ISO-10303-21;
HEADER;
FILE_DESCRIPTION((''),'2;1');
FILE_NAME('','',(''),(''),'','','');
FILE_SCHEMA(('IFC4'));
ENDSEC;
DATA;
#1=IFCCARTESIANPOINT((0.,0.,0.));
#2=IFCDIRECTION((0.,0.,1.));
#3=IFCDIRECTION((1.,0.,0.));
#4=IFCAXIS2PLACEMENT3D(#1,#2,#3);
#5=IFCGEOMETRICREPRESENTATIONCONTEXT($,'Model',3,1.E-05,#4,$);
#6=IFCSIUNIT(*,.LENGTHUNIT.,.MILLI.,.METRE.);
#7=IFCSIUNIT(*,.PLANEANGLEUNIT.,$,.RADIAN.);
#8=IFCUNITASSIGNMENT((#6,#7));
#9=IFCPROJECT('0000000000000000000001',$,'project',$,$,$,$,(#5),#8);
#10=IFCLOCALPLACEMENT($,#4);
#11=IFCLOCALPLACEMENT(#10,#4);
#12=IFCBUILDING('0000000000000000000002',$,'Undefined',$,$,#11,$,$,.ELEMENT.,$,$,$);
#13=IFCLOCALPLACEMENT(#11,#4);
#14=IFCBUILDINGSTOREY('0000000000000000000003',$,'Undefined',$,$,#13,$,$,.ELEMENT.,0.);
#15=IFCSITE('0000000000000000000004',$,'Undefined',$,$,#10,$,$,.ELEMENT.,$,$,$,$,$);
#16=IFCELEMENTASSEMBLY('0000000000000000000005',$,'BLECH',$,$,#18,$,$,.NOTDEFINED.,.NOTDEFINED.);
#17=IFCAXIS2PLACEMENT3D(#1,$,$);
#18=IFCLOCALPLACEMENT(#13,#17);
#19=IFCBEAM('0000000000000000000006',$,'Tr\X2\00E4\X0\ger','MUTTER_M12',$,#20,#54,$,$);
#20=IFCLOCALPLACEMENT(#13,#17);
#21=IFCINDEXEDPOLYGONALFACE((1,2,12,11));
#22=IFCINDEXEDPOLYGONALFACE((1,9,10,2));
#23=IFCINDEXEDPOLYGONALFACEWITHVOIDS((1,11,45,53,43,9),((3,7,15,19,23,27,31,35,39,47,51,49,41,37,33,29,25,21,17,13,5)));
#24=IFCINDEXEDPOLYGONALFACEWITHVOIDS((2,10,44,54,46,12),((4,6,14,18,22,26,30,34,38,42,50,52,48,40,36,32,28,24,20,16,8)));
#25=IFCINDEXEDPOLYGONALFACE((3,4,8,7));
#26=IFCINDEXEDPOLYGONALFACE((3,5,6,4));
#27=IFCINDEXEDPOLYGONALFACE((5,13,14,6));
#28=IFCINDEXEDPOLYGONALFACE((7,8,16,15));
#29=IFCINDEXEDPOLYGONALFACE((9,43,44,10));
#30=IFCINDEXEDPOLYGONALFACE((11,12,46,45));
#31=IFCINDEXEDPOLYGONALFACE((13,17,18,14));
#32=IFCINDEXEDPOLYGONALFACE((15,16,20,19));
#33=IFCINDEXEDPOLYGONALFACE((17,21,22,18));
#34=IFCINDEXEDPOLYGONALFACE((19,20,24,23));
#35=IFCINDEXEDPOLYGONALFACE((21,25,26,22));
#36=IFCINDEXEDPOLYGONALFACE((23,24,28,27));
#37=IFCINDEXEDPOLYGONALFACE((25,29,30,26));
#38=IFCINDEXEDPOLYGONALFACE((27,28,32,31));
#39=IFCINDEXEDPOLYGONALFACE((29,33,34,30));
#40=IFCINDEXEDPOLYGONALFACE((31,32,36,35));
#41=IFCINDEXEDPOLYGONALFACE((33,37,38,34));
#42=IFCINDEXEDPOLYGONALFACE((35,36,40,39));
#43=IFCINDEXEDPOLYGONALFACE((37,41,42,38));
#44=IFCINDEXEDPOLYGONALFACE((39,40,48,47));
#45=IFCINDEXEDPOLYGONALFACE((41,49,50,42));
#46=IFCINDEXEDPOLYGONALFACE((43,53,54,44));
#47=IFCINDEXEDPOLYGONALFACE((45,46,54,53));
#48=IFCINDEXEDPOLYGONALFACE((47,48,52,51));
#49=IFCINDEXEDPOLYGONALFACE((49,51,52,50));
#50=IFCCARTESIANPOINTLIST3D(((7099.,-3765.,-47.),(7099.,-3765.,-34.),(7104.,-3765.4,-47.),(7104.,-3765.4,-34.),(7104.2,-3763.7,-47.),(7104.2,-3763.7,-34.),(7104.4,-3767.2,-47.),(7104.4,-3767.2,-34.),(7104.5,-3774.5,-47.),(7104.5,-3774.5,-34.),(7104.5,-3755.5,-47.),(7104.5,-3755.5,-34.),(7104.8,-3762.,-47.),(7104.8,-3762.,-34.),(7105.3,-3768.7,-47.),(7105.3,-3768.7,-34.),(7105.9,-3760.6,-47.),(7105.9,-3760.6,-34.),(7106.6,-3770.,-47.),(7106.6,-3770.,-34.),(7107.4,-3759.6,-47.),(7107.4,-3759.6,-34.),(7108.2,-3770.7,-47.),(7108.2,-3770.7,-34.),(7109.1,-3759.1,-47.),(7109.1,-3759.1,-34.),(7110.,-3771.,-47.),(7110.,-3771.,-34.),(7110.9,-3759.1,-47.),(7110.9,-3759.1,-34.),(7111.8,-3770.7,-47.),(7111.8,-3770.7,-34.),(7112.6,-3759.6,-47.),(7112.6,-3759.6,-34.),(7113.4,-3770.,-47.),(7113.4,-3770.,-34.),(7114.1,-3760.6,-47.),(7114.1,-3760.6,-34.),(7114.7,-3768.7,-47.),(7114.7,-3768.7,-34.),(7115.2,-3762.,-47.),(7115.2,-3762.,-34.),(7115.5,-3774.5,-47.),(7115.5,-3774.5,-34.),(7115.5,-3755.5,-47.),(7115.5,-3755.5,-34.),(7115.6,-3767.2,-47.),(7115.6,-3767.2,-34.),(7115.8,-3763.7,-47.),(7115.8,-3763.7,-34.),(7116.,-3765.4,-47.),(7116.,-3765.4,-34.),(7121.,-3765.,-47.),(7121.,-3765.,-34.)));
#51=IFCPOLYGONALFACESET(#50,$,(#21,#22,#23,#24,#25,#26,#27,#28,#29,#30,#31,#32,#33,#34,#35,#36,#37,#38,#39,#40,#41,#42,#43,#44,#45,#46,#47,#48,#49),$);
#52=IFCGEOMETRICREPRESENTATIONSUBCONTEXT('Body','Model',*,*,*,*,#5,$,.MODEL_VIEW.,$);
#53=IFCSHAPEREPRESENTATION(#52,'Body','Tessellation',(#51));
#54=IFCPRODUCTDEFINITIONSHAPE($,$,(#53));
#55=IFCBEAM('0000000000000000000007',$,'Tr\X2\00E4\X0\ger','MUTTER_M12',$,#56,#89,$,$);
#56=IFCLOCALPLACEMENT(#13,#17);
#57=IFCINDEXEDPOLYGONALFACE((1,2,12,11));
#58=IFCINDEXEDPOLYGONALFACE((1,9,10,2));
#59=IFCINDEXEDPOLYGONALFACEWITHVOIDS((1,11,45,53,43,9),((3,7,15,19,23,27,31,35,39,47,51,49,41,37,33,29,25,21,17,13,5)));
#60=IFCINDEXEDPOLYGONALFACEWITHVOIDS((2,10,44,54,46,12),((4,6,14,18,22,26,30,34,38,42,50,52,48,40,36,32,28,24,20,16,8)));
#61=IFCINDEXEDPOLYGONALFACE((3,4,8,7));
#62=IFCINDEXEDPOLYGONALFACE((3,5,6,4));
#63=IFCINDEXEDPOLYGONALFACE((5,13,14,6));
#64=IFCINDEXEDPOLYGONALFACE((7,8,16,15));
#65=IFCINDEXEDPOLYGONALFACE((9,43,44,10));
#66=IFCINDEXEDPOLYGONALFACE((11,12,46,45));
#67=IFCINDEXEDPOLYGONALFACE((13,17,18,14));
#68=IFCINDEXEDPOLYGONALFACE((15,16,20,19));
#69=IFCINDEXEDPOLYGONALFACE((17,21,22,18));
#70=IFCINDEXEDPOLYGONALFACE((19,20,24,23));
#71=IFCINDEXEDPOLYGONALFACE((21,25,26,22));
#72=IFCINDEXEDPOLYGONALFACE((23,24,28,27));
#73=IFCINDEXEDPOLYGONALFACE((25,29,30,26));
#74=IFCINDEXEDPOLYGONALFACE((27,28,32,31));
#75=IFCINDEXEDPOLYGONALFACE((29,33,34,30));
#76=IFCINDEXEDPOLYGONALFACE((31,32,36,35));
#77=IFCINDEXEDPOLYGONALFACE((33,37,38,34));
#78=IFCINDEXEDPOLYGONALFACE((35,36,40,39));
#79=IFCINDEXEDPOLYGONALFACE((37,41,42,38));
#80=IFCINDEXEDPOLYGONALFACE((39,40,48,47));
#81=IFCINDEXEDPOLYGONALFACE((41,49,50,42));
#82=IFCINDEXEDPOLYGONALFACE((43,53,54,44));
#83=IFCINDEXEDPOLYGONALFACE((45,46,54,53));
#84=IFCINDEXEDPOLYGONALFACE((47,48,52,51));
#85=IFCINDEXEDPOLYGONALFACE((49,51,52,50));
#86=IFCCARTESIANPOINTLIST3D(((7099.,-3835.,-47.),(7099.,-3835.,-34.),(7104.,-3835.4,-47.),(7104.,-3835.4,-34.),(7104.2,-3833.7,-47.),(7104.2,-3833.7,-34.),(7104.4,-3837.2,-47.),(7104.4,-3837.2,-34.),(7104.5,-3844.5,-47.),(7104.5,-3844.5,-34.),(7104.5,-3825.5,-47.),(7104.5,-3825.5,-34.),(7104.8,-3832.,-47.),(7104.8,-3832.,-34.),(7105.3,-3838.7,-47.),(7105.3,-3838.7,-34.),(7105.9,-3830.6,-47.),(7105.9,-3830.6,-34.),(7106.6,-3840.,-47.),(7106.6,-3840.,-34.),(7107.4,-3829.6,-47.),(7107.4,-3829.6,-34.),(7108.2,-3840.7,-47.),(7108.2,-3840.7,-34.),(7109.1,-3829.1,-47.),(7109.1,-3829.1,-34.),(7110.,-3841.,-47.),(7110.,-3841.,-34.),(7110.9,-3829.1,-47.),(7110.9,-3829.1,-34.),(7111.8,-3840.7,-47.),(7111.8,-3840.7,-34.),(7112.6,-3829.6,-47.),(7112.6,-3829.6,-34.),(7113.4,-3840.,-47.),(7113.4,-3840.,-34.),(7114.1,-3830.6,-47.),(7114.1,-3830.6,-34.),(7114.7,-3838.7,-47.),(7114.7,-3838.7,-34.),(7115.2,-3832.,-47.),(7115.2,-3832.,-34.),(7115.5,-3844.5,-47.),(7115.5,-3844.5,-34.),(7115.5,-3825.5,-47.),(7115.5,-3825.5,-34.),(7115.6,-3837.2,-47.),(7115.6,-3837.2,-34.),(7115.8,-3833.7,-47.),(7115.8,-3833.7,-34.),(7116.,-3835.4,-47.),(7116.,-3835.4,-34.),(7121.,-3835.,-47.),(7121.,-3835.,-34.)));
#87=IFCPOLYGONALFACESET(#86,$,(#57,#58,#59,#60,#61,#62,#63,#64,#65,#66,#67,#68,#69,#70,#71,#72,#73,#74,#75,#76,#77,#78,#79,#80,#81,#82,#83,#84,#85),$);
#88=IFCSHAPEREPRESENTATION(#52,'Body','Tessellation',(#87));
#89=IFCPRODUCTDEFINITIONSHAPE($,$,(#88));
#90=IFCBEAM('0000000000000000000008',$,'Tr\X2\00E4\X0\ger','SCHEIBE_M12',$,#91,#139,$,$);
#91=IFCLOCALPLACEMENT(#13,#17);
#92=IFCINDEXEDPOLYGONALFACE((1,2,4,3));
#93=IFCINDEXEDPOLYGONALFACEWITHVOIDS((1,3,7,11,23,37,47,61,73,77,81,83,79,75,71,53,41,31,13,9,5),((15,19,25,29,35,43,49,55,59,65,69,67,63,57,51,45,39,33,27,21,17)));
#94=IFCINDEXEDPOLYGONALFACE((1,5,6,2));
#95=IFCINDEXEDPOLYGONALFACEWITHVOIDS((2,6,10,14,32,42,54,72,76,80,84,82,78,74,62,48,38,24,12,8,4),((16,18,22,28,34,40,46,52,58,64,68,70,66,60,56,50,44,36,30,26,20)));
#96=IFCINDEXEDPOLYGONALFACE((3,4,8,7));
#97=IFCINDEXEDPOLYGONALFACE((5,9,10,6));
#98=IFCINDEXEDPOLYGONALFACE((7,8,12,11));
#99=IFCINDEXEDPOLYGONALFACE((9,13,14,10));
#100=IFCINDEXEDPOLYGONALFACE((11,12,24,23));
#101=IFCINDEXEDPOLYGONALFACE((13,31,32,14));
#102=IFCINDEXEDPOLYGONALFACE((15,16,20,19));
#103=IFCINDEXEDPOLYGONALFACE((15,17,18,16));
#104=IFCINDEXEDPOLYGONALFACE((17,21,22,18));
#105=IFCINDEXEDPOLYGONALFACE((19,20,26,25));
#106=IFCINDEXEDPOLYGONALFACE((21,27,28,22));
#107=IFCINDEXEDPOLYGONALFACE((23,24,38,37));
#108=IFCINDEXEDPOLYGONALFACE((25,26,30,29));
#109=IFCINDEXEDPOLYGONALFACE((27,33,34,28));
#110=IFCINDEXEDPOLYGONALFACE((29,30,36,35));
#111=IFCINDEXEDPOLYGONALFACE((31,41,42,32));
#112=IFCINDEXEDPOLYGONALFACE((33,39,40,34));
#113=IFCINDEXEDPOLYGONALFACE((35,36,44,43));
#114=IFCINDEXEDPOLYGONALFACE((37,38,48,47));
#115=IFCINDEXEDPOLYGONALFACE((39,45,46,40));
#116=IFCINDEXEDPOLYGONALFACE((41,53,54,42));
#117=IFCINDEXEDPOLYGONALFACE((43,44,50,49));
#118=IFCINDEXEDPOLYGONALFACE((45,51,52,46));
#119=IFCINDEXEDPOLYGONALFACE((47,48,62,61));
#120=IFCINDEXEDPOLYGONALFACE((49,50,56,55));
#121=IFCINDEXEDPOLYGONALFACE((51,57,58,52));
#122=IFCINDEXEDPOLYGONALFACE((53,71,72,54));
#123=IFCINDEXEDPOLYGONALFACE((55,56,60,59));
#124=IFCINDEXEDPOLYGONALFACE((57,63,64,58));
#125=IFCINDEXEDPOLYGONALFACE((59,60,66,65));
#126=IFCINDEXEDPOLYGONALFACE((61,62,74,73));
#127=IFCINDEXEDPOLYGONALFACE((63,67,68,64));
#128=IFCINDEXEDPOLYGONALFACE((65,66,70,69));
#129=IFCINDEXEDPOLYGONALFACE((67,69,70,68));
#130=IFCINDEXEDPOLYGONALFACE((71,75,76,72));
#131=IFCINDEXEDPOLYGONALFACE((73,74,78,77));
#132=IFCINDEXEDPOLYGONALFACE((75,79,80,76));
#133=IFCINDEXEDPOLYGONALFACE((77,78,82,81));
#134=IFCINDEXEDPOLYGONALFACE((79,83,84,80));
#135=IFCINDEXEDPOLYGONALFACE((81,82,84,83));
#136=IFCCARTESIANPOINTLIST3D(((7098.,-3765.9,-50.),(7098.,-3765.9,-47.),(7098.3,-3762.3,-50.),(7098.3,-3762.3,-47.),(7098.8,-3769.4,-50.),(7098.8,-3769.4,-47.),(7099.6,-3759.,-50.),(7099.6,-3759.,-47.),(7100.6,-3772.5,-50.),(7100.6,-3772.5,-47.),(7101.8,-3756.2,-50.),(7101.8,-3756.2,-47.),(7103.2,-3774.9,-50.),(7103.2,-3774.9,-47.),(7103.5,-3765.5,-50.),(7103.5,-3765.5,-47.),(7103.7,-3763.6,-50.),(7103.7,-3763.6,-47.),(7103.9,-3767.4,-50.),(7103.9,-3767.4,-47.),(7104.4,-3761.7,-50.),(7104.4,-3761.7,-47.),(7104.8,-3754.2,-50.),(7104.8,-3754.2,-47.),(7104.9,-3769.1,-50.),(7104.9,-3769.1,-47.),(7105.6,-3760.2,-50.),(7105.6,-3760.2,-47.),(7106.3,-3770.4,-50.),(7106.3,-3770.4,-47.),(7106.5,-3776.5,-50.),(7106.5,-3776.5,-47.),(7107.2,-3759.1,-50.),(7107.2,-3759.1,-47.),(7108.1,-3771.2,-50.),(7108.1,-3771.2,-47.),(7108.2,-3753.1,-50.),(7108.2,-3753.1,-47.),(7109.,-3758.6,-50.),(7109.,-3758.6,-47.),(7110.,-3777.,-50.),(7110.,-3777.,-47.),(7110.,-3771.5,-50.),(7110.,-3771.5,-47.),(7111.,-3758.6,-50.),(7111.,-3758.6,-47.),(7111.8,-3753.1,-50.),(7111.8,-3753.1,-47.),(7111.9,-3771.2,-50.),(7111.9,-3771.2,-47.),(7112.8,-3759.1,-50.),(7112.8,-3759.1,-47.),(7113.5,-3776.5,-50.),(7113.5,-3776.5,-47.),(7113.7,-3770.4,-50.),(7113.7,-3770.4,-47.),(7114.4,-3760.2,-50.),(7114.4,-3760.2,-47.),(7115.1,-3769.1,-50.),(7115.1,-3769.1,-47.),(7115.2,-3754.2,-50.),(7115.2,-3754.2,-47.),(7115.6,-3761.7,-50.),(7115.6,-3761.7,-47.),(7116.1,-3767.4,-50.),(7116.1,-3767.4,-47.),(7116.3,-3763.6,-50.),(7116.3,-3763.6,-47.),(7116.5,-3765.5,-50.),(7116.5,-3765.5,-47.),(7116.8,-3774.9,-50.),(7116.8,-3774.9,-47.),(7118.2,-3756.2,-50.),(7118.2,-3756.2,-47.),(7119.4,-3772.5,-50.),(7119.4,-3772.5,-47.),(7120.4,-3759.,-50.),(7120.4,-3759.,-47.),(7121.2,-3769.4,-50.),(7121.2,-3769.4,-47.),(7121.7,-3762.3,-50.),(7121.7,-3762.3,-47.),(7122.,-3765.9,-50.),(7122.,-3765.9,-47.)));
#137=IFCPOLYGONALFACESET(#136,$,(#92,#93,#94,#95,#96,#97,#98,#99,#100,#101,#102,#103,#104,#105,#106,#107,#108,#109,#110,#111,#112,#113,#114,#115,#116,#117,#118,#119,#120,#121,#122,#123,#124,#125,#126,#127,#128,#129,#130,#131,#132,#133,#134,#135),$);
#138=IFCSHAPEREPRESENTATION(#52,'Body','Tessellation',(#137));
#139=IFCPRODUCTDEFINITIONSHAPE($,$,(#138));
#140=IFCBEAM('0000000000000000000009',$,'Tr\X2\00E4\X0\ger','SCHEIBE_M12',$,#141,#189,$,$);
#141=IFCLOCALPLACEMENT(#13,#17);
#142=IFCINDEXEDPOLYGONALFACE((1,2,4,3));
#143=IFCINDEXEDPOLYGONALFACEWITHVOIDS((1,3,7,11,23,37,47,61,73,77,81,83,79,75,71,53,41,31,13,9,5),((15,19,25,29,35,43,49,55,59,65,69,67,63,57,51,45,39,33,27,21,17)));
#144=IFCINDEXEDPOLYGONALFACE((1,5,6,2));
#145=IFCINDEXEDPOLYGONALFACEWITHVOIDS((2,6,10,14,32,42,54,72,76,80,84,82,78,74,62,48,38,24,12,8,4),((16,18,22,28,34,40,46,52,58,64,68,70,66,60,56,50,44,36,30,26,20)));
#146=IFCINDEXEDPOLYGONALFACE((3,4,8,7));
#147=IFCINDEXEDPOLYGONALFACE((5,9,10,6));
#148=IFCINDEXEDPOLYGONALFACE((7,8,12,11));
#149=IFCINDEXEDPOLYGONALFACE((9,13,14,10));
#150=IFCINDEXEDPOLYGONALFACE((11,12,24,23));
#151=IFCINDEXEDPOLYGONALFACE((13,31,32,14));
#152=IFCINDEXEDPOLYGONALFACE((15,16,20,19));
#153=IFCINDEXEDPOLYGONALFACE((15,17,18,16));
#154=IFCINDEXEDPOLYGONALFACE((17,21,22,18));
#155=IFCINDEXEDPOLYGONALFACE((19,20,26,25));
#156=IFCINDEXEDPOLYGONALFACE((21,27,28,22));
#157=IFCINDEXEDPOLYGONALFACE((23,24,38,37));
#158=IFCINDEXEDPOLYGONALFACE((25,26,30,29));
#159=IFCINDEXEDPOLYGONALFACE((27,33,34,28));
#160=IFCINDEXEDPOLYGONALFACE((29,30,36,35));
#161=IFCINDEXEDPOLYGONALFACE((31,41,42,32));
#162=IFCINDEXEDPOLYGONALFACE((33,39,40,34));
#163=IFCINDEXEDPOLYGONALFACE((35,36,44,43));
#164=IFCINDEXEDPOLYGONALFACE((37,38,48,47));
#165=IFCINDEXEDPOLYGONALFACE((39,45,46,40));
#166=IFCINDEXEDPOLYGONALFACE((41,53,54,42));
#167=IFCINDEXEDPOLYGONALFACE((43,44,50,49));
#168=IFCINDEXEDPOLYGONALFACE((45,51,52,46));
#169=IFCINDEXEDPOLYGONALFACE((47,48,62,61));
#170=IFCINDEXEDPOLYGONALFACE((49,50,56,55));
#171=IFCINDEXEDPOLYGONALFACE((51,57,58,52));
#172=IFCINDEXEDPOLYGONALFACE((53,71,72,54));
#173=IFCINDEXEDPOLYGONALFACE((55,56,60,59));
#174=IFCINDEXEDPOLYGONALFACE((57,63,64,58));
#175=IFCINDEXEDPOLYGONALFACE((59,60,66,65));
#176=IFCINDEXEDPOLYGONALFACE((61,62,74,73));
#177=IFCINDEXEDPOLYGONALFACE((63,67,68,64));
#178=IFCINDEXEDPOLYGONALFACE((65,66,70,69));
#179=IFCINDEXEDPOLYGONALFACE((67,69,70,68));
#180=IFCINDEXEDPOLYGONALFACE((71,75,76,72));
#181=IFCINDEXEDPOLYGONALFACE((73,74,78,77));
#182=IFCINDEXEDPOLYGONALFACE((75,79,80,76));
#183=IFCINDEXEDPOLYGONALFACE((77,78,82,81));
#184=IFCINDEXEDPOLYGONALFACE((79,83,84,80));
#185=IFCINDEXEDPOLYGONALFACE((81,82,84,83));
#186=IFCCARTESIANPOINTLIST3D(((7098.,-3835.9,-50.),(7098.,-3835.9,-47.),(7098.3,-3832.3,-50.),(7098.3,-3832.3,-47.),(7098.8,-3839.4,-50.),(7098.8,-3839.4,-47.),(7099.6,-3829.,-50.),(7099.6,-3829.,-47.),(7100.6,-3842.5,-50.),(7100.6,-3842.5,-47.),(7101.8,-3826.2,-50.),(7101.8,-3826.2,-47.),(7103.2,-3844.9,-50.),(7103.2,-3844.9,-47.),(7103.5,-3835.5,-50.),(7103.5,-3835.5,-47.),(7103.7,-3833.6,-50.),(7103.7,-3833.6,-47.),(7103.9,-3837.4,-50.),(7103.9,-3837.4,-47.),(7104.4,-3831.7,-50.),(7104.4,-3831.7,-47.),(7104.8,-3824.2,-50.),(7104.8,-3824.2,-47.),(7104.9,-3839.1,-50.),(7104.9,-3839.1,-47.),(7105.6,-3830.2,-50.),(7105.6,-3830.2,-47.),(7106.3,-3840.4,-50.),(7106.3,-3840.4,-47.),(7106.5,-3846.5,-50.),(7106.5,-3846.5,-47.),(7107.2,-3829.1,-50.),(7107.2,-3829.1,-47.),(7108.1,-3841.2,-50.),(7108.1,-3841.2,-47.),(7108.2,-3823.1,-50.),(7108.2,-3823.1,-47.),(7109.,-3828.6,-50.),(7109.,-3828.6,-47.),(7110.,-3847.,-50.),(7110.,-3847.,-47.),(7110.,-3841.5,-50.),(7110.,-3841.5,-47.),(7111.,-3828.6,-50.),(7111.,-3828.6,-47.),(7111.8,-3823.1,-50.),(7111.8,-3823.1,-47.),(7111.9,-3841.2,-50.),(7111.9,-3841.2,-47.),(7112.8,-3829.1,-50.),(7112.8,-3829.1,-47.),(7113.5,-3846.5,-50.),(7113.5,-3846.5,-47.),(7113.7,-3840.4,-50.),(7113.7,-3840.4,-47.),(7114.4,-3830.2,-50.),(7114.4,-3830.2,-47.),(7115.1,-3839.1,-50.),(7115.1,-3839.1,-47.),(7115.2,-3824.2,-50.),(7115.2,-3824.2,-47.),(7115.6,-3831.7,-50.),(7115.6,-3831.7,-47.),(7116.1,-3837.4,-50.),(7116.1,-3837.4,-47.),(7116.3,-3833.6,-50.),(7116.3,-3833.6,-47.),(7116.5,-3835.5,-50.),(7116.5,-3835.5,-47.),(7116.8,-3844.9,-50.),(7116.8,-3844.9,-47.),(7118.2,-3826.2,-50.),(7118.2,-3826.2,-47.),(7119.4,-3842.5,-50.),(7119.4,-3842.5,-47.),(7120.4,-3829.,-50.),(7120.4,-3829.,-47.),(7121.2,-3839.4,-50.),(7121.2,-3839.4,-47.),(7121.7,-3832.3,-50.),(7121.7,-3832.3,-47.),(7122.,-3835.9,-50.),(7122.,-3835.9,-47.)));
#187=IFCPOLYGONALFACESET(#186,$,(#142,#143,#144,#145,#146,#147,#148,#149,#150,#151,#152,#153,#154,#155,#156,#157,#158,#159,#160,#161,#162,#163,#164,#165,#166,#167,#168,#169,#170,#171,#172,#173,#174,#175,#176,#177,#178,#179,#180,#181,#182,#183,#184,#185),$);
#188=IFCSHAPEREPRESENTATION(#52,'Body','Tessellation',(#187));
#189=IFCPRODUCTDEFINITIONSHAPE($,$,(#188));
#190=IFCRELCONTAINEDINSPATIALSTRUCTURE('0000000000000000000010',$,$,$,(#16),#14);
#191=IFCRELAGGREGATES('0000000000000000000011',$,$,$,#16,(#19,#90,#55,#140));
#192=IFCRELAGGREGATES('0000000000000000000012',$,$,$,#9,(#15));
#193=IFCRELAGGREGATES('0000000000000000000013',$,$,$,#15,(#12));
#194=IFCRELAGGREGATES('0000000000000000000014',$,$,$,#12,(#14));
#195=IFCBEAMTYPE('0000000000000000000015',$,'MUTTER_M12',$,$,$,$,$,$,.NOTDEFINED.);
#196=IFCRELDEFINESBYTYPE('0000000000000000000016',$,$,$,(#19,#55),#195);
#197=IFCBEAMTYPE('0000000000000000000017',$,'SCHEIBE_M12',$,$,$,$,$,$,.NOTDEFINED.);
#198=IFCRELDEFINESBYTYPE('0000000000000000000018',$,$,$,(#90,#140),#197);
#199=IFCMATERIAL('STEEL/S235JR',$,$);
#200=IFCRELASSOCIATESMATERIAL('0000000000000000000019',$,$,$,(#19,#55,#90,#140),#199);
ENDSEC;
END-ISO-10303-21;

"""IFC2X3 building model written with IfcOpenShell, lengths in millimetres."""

from ifc_helpers import new_model, si_unit, frame, origin_with_axes, origin_2d_with_axis, place, context, subcontext, project, spatial, polyline, circle, hollow_circle, outline, extrude, boolean, material, type_object, element, aggregate, save


model = new_model("IFC2X3")

# Units and contexts
model_context = context("Model", 3, precision=1e-05, world=origin_with_axes())
body_context = subcontext(model_context, "Body", "Model", "MODEL_VIEW")
ifc_project = project(units=[si_unit("LENGTHUNIT", "METRE", prefix="MILLI"), si_unit("PLANEANGLEUNIT", "RADIAN")], contexts=[model_context])

# Site, building, storey
site_placement = place(None, origin_with_axes())
site = spatial("IfcSite", under=ifc_project, at=site_placement, Name="Undefined", CompositionType="ELEMENT")
building_placement = place(site_placement, origin_with_axes())
building = spatial("IfcBuilding", under=site, at=building_placement, Name="Undefined", CompositionType="ELEMENT")
storey_placement = place(building_placement, origin_with_axes())
storey = spatial("IfcBuildingStorey", under=building, at=storey_placement, Name="Undefined", CompositionType="ELEMENT", Elevation=0.0)

# Element assembly, beams
assembly_1_placement = place(storey_placement, origin_with_axes())
assembly_1 = element("IfcElementAssembly", 1, at=assembly_1_placement, inside=storey, Name="BLECH", AssemblyPlace="NOTDEFINED", PredefinedType="NOTDEFINED")
ifc_material_1 = material(Name="STEEL/S235JR")
beam_type_1 = type_object("IfcBeamType", Name="MUTTER_M12", PredefinedType="NOTDEFINED")
beam_1_placement = place(assembly_1_placement, frame((7110.0, -3765.0, -34.0), z_axis=(1.0, 0.0, 0.0), x_axis=(0.0, 0.0, -1.0)))
beam_1 = element("IfcBeam", 2, at=beam_1_placement, type_object=beam_type_1, material=ifc_material_1, Name="Träger", Description="MUTTER_M12", context=body_context, shape_type="CSG", body=[
    boolean("DIFFERENCE", extrude(outline(polyline([(9.5, 5.5), (9.5, -5.5), (0.0, -11.0), (-9.5, -5.5), (-9.5, 5.5), (0.0, 11.0), (9.5, 5.5)])), frame((13.0, 0.0, 0.0), z_axis=(-1.0, 0.0, 0.0), x_axis=(0.0, -1.0, 0.0)), (0.0, 0.0, 1.0), 13.0), extrude(circle(Radius=6.0, at=origin_2d_with_axis()), frame((36.0, 0.0, 0.0), z_axis=(-1.0, 0.0, 0.0), x_axis=(0.0, -1.0, 0.0)), (0.0, 0.0, 1.0), 60.0)),
])
beam_2_placement = place(assembly_1_placement, frame((7110.0, -3835.0, -34.0), z_axis=(1.0, 0.0, 0.0), x_axis=(0.0, 0.0, -1.0)))
beam_2 = element("IfcBeam", 3, at=beam_2_placement, type_object=beam_type_1, material=ifc_material_1, Name="Träger", Description="MUTTER_M12", context=body_context, shape_type="CSG", body=[
    boolean("DIFFERENCE", extrude(outline(polyline([(9.5, 5.5), (9.5, -5.5), (0.0, -11.0), (-9.5, -5.5), (-9.5, 5.5), (0.0, 11.0), (9.5, 5.5)])), frame((13.0, 0.0, 0.0), z_axis=(-1.0, 0.0, 0.0), x_axis=(0.0, -1.0, 0.0)), (0.0, 0.0, 1.0), 13.0), extrude(circle(Radius=6.0, at=origin_2d_with_axis()), frame((36.0, 0.0, 0.0), z_axis=(-1.0, 0.0, 0.0), x_axis=(0.0, -1.0, 0.0)), (0.0, 0.0, 1.0), 60.0)),
])
beam_type_2 = type_object("IfcBeamType", Name="SCHEIBE_M12", PredefinedType="NOTDEFINED")
beam_3_placement = place(assembly_1_placement, frame((7110.0, -3765.0, -47.0), z_axis=(1.0, 0.0, 0.0), x_axis=(0.0, 0.0, -1.0)))
beam_3 = element("IfcBeam", 4, at=beam_3_placement, type_object=beam_type_2, material=ifc_material_1, Name="Träger", Description="SCHEIBE_M12", context=body_context, shape_type="SweptSolid", body=[
    extrude(hollow_circle(Radius=12.0, WallThickness=5.5, at=origin_2d_with_axis()), frame((3.0, 0.0, 0.0), z_axis=(-1.0, 0.0, 0.0), x_axis=(0.0, -1.0, 0.0)), (0.0, 0.0, 1.0), 3.0),
])
beam_4_placement = place(assembly_1_placement, frame((7110.0, -3835.0, -47.0), z_axis=(1.0, 0.0, 0.0), x_axis=(0.0, 0.0, -1.0)))
beam_4 = element("IfcBeam", 5, at=beam_4_placement, type_object=beam_type_2, material=ifc_material_1, Name="Träger", Description="SCHEIBE_M12", context=body_context, shape_type="SweptSolid", body=[
    extrude(hollow_circle(Radius=12.0, WallThickness=5.5, at=origin_2d_with_axis()), frame((3.0, 0.0, 0.0), z_axis=(-1.0, 0.0, 0.0), x_axis=(0.0, -1.0, 0.0)), (0.0, 0.0, 1.0), 3.0),
])

aggregate(assembly_1, [beam_1, beam_3, beam_2, beam_4])

save(model, "model.ifc")
